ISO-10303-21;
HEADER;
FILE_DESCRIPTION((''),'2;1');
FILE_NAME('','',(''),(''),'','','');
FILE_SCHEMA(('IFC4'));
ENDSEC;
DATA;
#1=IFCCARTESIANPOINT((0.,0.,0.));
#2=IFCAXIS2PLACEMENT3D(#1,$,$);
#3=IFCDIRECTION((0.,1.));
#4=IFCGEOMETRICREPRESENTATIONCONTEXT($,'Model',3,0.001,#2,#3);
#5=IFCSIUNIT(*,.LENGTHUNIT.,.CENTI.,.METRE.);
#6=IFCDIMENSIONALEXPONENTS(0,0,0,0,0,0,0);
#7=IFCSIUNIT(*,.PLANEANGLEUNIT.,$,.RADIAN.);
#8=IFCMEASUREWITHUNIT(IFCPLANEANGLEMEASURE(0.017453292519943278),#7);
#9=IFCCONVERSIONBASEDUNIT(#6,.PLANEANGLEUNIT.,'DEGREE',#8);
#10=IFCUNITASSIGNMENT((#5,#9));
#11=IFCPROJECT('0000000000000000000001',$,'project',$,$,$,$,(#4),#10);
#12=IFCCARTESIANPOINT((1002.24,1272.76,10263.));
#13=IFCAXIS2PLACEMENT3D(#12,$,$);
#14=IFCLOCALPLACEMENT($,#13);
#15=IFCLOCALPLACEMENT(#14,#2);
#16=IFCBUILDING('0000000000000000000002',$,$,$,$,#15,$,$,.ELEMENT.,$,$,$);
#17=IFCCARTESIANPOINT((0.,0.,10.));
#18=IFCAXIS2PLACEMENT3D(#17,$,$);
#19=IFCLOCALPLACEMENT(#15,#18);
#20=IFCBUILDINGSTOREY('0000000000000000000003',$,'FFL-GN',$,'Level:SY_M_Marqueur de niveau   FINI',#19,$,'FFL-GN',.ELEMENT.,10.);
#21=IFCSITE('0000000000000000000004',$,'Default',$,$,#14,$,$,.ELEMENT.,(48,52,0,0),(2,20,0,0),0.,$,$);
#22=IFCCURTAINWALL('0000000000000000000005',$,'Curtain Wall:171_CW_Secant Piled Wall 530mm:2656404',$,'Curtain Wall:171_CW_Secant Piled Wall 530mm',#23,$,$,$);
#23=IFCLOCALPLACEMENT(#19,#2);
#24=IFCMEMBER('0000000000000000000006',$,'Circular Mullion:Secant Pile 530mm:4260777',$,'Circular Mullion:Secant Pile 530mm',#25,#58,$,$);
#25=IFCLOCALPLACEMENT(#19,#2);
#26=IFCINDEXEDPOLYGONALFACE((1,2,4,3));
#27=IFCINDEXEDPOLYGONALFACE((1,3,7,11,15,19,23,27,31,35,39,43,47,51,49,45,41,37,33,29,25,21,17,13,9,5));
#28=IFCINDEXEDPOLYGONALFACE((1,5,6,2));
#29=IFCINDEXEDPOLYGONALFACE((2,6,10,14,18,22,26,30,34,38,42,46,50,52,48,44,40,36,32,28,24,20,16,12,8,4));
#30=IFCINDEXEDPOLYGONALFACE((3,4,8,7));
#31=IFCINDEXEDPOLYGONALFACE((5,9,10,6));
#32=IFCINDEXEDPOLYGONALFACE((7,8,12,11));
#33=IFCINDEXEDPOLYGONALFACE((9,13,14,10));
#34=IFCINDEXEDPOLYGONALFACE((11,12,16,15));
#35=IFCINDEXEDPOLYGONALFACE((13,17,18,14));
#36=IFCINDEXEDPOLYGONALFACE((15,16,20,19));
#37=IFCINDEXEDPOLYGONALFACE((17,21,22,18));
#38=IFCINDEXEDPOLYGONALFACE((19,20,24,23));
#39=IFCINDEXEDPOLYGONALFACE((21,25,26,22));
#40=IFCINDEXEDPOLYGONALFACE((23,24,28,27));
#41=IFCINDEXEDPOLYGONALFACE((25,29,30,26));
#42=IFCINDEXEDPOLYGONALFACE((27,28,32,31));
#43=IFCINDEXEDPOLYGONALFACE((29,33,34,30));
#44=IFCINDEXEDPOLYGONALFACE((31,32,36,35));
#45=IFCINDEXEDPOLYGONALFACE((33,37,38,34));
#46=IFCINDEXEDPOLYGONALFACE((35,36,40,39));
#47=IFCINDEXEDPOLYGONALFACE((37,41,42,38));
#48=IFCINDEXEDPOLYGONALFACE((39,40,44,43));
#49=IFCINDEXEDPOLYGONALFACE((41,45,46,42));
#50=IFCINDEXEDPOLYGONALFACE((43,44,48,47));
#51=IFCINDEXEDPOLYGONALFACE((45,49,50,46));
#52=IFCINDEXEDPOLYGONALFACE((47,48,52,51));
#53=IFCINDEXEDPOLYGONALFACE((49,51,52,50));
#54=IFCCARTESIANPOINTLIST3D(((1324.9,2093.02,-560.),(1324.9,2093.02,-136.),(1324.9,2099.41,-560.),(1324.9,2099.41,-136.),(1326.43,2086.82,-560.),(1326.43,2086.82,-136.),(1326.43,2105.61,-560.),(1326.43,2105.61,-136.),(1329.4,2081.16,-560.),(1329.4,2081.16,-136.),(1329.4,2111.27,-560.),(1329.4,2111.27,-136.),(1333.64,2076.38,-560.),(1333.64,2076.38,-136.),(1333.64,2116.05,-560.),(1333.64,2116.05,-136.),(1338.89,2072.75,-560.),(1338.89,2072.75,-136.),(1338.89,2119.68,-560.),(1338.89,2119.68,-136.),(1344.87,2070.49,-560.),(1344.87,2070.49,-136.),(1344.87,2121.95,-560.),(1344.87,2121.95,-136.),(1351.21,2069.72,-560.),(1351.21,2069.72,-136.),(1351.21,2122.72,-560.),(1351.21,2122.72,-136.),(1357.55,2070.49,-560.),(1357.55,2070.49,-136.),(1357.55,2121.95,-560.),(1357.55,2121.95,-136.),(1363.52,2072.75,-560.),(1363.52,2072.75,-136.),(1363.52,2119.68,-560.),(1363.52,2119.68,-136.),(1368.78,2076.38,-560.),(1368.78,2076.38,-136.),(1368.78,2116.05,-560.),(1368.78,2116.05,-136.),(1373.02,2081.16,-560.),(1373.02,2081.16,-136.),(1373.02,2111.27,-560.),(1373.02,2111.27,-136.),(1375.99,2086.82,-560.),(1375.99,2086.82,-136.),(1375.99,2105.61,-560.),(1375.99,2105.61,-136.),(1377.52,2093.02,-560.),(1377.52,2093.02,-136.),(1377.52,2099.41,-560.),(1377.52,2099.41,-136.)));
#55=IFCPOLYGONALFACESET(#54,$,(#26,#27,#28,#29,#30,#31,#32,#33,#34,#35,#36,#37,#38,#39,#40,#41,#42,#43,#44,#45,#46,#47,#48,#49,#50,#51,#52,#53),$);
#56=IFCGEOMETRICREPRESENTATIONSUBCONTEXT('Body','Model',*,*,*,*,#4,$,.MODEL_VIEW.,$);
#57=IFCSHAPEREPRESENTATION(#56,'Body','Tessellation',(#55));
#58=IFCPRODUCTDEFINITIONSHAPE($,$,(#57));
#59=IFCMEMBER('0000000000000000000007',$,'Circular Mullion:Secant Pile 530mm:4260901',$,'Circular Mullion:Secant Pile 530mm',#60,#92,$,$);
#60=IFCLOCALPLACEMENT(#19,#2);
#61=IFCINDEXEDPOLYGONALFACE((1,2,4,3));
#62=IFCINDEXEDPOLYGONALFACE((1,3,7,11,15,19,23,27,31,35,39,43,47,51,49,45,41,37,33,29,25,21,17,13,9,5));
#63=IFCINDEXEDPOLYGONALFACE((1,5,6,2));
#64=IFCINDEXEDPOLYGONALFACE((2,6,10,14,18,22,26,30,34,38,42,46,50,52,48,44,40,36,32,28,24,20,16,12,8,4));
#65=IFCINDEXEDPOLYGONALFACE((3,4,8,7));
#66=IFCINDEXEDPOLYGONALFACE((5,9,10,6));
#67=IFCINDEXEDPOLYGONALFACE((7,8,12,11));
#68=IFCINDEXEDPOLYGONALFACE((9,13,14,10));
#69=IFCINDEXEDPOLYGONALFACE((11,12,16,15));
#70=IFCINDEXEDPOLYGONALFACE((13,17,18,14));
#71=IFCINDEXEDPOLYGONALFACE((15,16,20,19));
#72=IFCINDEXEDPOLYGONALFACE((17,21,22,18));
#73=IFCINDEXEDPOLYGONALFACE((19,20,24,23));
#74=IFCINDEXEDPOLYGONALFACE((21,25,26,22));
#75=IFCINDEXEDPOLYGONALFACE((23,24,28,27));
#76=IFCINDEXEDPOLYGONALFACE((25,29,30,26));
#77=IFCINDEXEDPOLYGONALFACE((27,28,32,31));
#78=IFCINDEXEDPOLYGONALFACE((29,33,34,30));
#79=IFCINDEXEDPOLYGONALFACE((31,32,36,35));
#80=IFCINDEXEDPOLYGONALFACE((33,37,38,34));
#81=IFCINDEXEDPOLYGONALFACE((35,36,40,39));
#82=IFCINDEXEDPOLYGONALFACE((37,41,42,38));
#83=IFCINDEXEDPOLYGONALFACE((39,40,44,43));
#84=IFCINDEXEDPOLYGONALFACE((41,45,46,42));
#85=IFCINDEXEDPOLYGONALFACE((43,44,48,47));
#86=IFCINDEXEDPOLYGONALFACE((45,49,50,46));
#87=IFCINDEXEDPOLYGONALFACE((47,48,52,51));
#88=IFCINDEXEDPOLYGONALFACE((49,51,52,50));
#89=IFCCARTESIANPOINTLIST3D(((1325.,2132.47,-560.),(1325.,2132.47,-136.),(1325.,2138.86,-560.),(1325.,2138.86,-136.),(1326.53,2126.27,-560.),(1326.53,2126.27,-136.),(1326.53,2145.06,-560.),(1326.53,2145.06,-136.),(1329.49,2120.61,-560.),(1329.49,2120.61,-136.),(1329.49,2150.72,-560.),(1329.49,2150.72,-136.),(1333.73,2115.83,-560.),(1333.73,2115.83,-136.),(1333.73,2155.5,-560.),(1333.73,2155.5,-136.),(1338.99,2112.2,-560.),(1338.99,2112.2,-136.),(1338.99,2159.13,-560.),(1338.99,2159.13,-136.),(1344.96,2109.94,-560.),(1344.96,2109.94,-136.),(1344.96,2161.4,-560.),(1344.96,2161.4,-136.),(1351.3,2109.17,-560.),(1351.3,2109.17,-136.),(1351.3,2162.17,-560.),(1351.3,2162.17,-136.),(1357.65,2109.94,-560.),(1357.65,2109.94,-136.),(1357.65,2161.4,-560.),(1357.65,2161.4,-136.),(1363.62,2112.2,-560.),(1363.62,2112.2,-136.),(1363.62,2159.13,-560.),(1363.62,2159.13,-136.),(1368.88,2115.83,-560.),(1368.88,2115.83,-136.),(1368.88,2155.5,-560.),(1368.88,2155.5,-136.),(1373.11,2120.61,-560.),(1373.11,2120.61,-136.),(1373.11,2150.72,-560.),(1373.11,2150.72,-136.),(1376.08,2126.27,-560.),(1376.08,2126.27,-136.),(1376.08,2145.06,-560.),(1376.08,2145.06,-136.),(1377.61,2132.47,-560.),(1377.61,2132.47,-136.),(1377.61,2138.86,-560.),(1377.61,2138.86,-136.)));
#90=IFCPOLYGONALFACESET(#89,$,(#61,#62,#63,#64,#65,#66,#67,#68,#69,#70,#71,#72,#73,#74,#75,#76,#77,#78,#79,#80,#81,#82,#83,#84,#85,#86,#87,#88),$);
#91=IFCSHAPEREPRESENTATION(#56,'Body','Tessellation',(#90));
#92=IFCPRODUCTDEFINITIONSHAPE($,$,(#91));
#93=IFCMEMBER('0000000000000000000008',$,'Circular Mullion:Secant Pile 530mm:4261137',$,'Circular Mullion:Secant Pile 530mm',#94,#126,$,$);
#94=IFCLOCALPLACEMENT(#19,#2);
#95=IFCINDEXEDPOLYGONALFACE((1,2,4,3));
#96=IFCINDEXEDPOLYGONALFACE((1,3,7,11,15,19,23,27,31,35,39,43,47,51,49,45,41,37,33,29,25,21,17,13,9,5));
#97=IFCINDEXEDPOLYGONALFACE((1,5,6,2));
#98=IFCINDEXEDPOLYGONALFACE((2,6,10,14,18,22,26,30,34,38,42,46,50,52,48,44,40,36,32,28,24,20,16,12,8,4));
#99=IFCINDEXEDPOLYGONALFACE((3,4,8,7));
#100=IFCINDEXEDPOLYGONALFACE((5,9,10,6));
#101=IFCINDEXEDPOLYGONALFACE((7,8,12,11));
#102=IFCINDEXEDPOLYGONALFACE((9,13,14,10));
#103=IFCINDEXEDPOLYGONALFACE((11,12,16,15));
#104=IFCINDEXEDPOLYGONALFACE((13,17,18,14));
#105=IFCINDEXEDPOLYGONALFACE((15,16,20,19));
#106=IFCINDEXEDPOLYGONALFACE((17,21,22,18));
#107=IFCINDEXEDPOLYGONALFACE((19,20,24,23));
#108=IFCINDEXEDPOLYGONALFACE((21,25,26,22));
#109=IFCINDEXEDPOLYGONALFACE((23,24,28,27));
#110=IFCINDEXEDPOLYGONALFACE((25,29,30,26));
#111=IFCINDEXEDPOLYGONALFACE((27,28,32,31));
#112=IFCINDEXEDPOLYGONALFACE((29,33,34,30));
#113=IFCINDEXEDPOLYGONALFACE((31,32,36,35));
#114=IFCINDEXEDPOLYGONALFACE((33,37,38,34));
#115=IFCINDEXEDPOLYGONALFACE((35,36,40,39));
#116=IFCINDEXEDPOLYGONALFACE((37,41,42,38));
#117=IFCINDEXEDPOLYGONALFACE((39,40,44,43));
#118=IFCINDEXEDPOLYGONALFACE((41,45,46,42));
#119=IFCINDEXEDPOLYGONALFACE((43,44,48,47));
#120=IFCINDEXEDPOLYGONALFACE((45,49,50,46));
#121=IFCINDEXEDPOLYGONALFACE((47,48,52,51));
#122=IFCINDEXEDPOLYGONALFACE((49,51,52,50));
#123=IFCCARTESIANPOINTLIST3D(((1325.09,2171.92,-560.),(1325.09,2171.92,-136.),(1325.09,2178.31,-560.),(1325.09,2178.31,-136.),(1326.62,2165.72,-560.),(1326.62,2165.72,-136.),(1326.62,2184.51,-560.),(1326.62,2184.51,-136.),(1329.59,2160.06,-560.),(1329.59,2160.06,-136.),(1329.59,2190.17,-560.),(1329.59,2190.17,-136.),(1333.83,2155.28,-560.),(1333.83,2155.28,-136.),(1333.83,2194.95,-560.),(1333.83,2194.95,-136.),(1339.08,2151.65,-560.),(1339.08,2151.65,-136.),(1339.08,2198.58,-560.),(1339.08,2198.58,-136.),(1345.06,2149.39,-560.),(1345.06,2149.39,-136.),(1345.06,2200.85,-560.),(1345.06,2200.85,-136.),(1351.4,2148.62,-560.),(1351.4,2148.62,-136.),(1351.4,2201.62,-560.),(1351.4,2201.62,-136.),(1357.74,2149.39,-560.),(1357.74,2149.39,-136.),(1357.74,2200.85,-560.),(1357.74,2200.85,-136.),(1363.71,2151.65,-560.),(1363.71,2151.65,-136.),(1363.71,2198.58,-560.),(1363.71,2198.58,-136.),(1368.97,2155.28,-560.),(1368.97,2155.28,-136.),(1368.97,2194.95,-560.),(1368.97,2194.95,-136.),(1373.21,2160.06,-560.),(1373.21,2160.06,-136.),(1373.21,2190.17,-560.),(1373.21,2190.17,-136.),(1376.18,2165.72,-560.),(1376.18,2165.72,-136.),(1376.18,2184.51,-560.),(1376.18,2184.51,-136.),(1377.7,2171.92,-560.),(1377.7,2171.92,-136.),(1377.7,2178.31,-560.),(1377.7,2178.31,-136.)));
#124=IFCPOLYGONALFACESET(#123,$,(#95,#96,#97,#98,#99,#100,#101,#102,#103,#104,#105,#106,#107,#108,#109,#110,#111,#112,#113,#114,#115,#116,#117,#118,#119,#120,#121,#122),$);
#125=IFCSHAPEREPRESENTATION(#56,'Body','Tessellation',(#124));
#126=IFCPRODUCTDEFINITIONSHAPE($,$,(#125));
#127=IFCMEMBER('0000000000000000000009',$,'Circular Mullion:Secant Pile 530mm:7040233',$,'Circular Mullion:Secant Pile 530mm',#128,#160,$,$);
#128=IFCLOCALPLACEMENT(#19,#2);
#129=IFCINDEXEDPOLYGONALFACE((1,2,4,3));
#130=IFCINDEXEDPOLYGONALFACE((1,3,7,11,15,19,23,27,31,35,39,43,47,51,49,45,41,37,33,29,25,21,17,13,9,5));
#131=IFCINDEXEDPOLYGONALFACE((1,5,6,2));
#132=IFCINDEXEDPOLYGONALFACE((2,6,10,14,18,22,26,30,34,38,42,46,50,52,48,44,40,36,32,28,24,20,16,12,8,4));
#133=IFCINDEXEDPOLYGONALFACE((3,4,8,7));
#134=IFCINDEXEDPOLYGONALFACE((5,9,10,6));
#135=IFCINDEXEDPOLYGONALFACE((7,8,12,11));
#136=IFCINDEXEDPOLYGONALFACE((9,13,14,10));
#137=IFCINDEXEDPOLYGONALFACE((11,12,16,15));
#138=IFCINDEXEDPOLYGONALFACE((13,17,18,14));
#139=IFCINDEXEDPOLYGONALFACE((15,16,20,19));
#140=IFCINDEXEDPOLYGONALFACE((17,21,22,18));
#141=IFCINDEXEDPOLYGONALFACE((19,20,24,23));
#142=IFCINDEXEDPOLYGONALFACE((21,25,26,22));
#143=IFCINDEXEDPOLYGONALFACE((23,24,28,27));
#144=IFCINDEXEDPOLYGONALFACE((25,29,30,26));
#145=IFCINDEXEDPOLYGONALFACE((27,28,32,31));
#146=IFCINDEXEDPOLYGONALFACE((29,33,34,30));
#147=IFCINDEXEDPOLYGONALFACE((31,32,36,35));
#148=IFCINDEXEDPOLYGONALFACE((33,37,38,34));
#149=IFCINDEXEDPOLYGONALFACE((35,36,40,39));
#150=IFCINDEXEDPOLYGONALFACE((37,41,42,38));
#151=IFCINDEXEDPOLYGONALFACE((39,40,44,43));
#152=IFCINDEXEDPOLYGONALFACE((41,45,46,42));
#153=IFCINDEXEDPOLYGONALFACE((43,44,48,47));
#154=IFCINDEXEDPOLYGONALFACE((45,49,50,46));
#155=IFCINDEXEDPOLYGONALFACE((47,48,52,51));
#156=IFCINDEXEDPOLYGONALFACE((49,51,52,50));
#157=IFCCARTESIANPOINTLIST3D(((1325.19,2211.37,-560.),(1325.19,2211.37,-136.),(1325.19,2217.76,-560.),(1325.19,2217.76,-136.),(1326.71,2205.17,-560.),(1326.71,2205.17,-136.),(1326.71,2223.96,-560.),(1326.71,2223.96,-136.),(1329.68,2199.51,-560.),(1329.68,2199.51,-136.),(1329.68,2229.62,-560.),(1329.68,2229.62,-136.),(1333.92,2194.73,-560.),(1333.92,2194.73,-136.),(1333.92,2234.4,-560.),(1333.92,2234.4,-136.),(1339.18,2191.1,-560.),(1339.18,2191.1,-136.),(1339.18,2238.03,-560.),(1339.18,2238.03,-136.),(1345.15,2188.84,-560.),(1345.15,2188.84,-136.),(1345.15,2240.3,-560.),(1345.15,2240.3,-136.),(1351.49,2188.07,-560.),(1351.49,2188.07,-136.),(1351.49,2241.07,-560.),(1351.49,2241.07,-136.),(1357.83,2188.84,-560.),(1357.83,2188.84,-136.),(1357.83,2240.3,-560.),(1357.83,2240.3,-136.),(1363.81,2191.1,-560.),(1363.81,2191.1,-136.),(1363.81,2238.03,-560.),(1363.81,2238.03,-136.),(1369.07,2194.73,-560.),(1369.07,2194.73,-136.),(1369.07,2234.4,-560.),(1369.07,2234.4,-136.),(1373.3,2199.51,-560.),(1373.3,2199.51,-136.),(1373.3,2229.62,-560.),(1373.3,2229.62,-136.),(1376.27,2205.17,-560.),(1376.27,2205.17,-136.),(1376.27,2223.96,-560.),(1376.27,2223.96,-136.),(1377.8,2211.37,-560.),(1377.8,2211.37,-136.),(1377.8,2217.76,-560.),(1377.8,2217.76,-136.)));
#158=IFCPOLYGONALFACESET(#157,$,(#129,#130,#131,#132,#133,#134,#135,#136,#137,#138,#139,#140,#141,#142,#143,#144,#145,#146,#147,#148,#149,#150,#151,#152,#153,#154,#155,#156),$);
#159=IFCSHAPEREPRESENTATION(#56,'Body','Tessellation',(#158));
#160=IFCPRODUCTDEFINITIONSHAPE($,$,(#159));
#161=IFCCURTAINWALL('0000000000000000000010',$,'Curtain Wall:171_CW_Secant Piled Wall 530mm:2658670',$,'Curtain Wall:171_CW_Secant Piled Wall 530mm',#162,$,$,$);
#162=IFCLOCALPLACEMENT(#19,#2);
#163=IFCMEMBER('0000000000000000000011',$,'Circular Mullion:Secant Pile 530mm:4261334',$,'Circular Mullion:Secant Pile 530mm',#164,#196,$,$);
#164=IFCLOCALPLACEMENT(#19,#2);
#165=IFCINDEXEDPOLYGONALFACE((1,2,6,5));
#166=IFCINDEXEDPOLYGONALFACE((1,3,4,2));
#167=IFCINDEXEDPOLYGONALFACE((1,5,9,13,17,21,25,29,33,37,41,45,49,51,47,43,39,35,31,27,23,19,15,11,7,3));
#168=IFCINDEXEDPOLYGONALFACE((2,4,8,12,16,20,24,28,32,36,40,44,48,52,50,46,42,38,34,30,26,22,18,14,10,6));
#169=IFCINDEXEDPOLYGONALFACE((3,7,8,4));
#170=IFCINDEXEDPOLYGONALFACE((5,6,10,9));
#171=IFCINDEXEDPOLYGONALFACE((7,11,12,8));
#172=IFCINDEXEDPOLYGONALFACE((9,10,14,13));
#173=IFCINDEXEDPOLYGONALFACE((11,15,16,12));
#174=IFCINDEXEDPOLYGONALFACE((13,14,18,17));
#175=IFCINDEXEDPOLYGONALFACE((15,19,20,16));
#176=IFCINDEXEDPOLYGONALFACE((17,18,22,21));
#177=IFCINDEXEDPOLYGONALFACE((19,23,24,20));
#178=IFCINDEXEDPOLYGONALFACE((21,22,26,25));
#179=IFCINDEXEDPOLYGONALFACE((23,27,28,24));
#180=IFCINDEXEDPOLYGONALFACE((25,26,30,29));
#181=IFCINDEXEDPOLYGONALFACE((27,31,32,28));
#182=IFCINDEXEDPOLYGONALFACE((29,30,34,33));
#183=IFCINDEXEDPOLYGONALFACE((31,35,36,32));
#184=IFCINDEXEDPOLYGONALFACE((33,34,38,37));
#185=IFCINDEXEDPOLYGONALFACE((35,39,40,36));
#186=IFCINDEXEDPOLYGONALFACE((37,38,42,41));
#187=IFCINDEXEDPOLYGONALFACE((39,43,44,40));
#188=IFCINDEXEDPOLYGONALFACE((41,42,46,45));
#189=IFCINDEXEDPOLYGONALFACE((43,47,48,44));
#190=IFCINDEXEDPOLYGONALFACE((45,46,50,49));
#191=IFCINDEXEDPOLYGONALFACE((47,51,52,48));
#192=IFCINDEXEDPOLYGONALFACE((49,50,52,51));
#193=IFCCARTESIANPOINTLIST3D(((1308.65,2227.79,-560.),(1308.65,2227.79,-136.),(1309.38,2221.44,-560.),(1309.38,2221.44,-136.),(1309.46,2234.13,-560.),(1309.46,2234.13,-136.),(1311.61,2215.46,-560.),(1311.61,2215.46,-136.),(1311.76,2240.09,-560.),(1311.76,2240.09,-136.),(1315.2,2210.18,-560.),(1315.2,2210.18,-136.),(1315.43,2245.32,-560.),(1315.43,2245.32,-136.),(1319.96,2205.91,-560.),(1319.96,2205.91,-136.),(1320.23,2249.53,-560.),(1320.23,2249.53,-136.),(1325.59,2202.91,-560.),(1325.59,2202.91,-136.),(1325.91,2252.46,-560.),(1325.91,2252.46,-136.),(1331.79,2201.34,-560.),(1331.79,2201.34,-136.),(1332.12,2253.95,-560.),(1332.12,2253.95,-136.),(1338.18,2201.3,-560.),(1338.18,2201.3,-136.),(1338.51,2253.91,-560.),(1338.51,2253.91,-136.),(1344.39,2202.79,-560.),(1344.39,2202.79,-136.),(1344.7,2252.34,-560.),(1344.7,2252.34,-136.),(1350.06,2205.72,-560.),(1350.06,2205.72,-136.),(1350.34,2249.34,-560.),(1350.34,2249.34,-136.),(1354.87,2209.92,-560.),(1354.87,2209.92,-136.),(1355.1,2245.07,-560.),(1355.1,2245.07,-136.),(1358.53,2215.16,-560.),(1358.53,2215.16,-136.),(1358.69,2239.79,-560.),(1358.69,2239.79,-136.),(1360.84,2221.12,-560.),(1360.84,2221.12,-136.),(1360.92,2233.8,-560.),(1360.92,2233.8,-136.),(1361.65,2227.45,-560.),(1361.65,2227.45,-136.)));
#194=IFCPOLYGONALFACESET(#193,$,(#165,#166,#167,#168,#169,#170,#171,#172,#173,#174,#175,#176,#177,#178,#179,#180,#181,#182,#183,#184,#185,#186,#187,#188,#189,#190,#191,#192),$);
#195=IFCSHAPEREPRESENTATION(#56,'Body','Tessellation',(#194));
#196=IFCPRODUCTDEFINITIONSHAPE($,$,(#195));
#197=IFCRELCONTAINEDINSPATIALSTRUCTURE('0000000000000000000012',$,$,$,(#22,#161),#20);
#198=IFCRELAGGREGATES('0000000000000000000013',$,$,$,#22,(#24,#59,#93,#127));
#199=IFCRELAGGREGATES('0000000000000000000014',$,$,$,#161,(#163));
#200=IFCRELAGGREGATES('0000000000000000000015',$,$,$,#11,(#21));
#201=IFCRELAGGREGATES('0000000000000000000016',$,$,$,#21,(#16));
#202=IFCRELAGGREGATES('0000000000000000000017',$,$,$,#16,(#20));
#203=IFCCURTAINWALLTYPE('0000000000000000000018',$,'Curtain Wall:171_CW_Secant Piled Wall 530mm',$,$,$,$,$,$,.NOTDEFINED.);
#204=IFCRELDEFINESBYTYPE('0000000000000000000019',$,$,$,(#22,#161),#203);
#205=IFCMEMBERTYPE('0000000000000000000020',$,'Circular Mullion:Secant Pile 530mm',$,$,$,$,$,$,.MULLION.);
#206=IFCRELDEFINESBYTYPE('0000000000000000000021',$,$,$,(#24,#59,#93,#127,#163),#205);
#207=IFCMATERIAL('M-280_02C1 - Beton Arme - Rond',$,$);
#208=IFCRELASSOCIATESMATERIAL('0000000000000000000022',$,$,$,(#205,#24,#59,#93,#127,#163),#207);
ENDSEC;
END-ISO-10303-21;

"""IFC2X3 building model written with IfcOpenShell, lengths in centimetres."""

from ifc_helpers import new_model, entity, si_unit, converted_unit, direction, frame, frame_2d, origin, place, context, subcontext, project, spatial, circle, extrude, source, transform, mapped, material, type_object, type_shapes, element, aggregate, save


model = new_model("IFC2X3")

# Units and contexts
model_context = context("Model", 3, precision=0.001, world=origin(), true_north=direction((0.0, 1.0)))
body_context = subcontext(model_context, "Body", "Model", "MODEL_VIEW")
ifc_project = project(units=[si_unit("LENGTHUNIT", "METRE", prefix="CENTI"), converted_unit("PLANEANGLEUNIT", "DEGREE", entity("IfcPlaneAngleMeasure", 0.017453292519943278), si_unit("PLANEANGLEUNIT", "RADIAN"), dimensions=[0, 0, 0, 0, 0, 0, 0])], contexts=[model_context])

# Site, building, storey
site_placement = place(None, frame((1002.24, 1272.76, 10263.0)))
site = spatial("IfcSite", under=ifc_project, at=site_placement, Name="Default", CompositionType="ELEMENT", RefLatitude=(48, 52, 0, 0), RefLongitude=(2, 20, 0, 0), RefElevation=0.0)
building_placement = place(site_placement, origin())
building = spatial("IfcBuilding", under=site, at=building_placement, CompositionType="ELEMENT")
storey_placement = place(building_placement, frame((0.0, 0.0, 10.0)))
storey = spatial("IfcBuildingStorey", under=building, at=storey_placement, Name="FFL-GN", ObjectType="Level:SY_M_Marqueur de niveau   FINI", LongName="FFL-GN", CompositionType="ELEMENT", Elevation=10.0)

# Curtain walls, members
curtain_wall_type = type_object("IfcCurtainWallType", Name="Curtain Wall:171_CW_Secant Piled Wall 530mm", PredefinedType="NOTDEFINED")
curtain_wall_1_placement = place(storey_placement, frame((0.0, 0.0, -10.0)))
curtain_wall_1 = element("IfcCurtainWall", 1, at=curtain_wall_1_placement, inside=storey, type_object=curtain_wall_type, Name="Curtain Wall:171_CW_Secant Piled Wall 530mm:2656404", ObjectType="Curtain Wall:171_CW_Secant Piled Wall 530mm")
ifc_material_1 = material(Name="M-280_02C1 - Beton Arme - Rond")
member_type = type_object("IfcMemberType", Name="Circular Mullion:Secant Pile 530mm", PredefinedType="MULLION", material=ifc_material_1)
shared_shape = source(origin(), body_context, "Body", "SweptSolid", [
    extrude(circle(Radius=26.5, at=frame_2d((0.0, 0.0), x_axis=(1.0, 0.0))), frame((0.0, 0.0, -424.0)), (0.0, 0.0, 1.0), 424.0),
])
type_shapes(member_type, [shared_shape])
member_1_placement = place(curtain_wall_1_placement, frame((1351.21, 2096.22, -550.0), z_axis=(0.0, 0.0, -1.0), x_axis=(0.0, 1.0, 0.0)))
member_1 = element("IfcMember", 2, at=member_1_placement, type_object=member_type, material=ifc_material_1, Name="Circular Mullion:Secant Pile 530mm:4260777", ObjectType="Circular Mullion:Secant Pile 530mm", context=body_context, shape_type="MappedRepresentation", body=[
    mapped(shared_shape, transform((0.0, 0.0, 0.0), scale=1.0)),
])
member_2_placement = place(curtain_wall_1_placement, frame((1351.3, 2135.67, -550.0), z_axis=(0.0, 0.0, -1.0), x_axis=(0.0, 1.0, 0.0)))
member_2 = element("IfcMember", 3, at=member_2_placement, type_object=member_type, material=ifc_material_1, Name="Circular Mullion:Secant Pile 530mm:4260901", ObjectType="Circular Mullion:Secant Pile 530mm", context=body_context, shape_type="MappedRepresentation", body=[
    mapped(shared_shape, transform((0.0, 0.0, 0.0), scale=1.0)),
])
member_3_placement = place(curtain_wall_1_placement, frame((1351.4, 2175.12, -550.0), z_axis=(0.0, 0.0, -1.0), x_axis=(0.0, 1.0, 0.0)))
member_3 = element("IfcMember", 4, at=member_3_placement, type_object=member_type, material=ifc_material_1, Name="Circular Mullion:Secant Pile 530mm:4261137", ObjectType="Circular Mullion:Secant Pile 530mm", context=body_context, shape_type="MappedRepresentation", body=[
    mapped(shared_shape, transform((0.0, 0.0, 0.0), scale=1.0)),
])
member_4_placement = place(curtain_wall_1_placement, frame((1351.49, 2214.57, -550.0), z_axis=(0.0, 0.0, -1.0), x_axis=(0.0, 1.0, 0.0)))
member_4 = element("IfcMember", 5, at=member_4_placement, type_object=member_type, material=ifc_material_1, Name="Circular Mullion:Secant Pile 530mm:7040233", ObjectType="Circular Mullion:Secant Pile 530mm", context=body_context, shape_type="MappedRepresentation", body=[
    mapped(shared_shape, transform((0.0, 0.0, 0.0), scale=1.0)),
])
aggregate(curtain_wall_1, [member_1, member_2, member_3, member_4])
curtain_wall_2_placement = place(storey_placement, frame((0.0, 0.0, -10.0)))
curtain_wall_2 = element("IfcCurtainWall", 6, at=curtain_wall_2_placement, inside=storey, type_object=curtain_wall_type, Name="Curtain Wall:171_CW_Secant Piled Wall 530mm:2658670", ObjectType="Curtain Wall:171_CW_Secant Piled Wall 530mm")
member_5_placement = place(curtain_wall_2_placement, frame((1335.15, 2227.62, -550.0), z_axis=(0.0, 0.0, -1.0), x_axis=(-0.99998, 0.006355, 0.0)))
member_5 = element("IfcMember", 7, at=member_5_placement, type_object=member_type, material=ifc_material_1, Name="Circular Mullion:Secant Pile 530mm:4261334", ObjectType="Circular Mullion:Secant Pile 530mm", context=body_context, shape_type="MappedRepresentation", body=[
    mapped(shared_shape, transform((0.0, 0.0, 0.0), scale=1.0)),
])
aggregate(curtain_wall_2, [member_5])

save(model, "model.ifc")
